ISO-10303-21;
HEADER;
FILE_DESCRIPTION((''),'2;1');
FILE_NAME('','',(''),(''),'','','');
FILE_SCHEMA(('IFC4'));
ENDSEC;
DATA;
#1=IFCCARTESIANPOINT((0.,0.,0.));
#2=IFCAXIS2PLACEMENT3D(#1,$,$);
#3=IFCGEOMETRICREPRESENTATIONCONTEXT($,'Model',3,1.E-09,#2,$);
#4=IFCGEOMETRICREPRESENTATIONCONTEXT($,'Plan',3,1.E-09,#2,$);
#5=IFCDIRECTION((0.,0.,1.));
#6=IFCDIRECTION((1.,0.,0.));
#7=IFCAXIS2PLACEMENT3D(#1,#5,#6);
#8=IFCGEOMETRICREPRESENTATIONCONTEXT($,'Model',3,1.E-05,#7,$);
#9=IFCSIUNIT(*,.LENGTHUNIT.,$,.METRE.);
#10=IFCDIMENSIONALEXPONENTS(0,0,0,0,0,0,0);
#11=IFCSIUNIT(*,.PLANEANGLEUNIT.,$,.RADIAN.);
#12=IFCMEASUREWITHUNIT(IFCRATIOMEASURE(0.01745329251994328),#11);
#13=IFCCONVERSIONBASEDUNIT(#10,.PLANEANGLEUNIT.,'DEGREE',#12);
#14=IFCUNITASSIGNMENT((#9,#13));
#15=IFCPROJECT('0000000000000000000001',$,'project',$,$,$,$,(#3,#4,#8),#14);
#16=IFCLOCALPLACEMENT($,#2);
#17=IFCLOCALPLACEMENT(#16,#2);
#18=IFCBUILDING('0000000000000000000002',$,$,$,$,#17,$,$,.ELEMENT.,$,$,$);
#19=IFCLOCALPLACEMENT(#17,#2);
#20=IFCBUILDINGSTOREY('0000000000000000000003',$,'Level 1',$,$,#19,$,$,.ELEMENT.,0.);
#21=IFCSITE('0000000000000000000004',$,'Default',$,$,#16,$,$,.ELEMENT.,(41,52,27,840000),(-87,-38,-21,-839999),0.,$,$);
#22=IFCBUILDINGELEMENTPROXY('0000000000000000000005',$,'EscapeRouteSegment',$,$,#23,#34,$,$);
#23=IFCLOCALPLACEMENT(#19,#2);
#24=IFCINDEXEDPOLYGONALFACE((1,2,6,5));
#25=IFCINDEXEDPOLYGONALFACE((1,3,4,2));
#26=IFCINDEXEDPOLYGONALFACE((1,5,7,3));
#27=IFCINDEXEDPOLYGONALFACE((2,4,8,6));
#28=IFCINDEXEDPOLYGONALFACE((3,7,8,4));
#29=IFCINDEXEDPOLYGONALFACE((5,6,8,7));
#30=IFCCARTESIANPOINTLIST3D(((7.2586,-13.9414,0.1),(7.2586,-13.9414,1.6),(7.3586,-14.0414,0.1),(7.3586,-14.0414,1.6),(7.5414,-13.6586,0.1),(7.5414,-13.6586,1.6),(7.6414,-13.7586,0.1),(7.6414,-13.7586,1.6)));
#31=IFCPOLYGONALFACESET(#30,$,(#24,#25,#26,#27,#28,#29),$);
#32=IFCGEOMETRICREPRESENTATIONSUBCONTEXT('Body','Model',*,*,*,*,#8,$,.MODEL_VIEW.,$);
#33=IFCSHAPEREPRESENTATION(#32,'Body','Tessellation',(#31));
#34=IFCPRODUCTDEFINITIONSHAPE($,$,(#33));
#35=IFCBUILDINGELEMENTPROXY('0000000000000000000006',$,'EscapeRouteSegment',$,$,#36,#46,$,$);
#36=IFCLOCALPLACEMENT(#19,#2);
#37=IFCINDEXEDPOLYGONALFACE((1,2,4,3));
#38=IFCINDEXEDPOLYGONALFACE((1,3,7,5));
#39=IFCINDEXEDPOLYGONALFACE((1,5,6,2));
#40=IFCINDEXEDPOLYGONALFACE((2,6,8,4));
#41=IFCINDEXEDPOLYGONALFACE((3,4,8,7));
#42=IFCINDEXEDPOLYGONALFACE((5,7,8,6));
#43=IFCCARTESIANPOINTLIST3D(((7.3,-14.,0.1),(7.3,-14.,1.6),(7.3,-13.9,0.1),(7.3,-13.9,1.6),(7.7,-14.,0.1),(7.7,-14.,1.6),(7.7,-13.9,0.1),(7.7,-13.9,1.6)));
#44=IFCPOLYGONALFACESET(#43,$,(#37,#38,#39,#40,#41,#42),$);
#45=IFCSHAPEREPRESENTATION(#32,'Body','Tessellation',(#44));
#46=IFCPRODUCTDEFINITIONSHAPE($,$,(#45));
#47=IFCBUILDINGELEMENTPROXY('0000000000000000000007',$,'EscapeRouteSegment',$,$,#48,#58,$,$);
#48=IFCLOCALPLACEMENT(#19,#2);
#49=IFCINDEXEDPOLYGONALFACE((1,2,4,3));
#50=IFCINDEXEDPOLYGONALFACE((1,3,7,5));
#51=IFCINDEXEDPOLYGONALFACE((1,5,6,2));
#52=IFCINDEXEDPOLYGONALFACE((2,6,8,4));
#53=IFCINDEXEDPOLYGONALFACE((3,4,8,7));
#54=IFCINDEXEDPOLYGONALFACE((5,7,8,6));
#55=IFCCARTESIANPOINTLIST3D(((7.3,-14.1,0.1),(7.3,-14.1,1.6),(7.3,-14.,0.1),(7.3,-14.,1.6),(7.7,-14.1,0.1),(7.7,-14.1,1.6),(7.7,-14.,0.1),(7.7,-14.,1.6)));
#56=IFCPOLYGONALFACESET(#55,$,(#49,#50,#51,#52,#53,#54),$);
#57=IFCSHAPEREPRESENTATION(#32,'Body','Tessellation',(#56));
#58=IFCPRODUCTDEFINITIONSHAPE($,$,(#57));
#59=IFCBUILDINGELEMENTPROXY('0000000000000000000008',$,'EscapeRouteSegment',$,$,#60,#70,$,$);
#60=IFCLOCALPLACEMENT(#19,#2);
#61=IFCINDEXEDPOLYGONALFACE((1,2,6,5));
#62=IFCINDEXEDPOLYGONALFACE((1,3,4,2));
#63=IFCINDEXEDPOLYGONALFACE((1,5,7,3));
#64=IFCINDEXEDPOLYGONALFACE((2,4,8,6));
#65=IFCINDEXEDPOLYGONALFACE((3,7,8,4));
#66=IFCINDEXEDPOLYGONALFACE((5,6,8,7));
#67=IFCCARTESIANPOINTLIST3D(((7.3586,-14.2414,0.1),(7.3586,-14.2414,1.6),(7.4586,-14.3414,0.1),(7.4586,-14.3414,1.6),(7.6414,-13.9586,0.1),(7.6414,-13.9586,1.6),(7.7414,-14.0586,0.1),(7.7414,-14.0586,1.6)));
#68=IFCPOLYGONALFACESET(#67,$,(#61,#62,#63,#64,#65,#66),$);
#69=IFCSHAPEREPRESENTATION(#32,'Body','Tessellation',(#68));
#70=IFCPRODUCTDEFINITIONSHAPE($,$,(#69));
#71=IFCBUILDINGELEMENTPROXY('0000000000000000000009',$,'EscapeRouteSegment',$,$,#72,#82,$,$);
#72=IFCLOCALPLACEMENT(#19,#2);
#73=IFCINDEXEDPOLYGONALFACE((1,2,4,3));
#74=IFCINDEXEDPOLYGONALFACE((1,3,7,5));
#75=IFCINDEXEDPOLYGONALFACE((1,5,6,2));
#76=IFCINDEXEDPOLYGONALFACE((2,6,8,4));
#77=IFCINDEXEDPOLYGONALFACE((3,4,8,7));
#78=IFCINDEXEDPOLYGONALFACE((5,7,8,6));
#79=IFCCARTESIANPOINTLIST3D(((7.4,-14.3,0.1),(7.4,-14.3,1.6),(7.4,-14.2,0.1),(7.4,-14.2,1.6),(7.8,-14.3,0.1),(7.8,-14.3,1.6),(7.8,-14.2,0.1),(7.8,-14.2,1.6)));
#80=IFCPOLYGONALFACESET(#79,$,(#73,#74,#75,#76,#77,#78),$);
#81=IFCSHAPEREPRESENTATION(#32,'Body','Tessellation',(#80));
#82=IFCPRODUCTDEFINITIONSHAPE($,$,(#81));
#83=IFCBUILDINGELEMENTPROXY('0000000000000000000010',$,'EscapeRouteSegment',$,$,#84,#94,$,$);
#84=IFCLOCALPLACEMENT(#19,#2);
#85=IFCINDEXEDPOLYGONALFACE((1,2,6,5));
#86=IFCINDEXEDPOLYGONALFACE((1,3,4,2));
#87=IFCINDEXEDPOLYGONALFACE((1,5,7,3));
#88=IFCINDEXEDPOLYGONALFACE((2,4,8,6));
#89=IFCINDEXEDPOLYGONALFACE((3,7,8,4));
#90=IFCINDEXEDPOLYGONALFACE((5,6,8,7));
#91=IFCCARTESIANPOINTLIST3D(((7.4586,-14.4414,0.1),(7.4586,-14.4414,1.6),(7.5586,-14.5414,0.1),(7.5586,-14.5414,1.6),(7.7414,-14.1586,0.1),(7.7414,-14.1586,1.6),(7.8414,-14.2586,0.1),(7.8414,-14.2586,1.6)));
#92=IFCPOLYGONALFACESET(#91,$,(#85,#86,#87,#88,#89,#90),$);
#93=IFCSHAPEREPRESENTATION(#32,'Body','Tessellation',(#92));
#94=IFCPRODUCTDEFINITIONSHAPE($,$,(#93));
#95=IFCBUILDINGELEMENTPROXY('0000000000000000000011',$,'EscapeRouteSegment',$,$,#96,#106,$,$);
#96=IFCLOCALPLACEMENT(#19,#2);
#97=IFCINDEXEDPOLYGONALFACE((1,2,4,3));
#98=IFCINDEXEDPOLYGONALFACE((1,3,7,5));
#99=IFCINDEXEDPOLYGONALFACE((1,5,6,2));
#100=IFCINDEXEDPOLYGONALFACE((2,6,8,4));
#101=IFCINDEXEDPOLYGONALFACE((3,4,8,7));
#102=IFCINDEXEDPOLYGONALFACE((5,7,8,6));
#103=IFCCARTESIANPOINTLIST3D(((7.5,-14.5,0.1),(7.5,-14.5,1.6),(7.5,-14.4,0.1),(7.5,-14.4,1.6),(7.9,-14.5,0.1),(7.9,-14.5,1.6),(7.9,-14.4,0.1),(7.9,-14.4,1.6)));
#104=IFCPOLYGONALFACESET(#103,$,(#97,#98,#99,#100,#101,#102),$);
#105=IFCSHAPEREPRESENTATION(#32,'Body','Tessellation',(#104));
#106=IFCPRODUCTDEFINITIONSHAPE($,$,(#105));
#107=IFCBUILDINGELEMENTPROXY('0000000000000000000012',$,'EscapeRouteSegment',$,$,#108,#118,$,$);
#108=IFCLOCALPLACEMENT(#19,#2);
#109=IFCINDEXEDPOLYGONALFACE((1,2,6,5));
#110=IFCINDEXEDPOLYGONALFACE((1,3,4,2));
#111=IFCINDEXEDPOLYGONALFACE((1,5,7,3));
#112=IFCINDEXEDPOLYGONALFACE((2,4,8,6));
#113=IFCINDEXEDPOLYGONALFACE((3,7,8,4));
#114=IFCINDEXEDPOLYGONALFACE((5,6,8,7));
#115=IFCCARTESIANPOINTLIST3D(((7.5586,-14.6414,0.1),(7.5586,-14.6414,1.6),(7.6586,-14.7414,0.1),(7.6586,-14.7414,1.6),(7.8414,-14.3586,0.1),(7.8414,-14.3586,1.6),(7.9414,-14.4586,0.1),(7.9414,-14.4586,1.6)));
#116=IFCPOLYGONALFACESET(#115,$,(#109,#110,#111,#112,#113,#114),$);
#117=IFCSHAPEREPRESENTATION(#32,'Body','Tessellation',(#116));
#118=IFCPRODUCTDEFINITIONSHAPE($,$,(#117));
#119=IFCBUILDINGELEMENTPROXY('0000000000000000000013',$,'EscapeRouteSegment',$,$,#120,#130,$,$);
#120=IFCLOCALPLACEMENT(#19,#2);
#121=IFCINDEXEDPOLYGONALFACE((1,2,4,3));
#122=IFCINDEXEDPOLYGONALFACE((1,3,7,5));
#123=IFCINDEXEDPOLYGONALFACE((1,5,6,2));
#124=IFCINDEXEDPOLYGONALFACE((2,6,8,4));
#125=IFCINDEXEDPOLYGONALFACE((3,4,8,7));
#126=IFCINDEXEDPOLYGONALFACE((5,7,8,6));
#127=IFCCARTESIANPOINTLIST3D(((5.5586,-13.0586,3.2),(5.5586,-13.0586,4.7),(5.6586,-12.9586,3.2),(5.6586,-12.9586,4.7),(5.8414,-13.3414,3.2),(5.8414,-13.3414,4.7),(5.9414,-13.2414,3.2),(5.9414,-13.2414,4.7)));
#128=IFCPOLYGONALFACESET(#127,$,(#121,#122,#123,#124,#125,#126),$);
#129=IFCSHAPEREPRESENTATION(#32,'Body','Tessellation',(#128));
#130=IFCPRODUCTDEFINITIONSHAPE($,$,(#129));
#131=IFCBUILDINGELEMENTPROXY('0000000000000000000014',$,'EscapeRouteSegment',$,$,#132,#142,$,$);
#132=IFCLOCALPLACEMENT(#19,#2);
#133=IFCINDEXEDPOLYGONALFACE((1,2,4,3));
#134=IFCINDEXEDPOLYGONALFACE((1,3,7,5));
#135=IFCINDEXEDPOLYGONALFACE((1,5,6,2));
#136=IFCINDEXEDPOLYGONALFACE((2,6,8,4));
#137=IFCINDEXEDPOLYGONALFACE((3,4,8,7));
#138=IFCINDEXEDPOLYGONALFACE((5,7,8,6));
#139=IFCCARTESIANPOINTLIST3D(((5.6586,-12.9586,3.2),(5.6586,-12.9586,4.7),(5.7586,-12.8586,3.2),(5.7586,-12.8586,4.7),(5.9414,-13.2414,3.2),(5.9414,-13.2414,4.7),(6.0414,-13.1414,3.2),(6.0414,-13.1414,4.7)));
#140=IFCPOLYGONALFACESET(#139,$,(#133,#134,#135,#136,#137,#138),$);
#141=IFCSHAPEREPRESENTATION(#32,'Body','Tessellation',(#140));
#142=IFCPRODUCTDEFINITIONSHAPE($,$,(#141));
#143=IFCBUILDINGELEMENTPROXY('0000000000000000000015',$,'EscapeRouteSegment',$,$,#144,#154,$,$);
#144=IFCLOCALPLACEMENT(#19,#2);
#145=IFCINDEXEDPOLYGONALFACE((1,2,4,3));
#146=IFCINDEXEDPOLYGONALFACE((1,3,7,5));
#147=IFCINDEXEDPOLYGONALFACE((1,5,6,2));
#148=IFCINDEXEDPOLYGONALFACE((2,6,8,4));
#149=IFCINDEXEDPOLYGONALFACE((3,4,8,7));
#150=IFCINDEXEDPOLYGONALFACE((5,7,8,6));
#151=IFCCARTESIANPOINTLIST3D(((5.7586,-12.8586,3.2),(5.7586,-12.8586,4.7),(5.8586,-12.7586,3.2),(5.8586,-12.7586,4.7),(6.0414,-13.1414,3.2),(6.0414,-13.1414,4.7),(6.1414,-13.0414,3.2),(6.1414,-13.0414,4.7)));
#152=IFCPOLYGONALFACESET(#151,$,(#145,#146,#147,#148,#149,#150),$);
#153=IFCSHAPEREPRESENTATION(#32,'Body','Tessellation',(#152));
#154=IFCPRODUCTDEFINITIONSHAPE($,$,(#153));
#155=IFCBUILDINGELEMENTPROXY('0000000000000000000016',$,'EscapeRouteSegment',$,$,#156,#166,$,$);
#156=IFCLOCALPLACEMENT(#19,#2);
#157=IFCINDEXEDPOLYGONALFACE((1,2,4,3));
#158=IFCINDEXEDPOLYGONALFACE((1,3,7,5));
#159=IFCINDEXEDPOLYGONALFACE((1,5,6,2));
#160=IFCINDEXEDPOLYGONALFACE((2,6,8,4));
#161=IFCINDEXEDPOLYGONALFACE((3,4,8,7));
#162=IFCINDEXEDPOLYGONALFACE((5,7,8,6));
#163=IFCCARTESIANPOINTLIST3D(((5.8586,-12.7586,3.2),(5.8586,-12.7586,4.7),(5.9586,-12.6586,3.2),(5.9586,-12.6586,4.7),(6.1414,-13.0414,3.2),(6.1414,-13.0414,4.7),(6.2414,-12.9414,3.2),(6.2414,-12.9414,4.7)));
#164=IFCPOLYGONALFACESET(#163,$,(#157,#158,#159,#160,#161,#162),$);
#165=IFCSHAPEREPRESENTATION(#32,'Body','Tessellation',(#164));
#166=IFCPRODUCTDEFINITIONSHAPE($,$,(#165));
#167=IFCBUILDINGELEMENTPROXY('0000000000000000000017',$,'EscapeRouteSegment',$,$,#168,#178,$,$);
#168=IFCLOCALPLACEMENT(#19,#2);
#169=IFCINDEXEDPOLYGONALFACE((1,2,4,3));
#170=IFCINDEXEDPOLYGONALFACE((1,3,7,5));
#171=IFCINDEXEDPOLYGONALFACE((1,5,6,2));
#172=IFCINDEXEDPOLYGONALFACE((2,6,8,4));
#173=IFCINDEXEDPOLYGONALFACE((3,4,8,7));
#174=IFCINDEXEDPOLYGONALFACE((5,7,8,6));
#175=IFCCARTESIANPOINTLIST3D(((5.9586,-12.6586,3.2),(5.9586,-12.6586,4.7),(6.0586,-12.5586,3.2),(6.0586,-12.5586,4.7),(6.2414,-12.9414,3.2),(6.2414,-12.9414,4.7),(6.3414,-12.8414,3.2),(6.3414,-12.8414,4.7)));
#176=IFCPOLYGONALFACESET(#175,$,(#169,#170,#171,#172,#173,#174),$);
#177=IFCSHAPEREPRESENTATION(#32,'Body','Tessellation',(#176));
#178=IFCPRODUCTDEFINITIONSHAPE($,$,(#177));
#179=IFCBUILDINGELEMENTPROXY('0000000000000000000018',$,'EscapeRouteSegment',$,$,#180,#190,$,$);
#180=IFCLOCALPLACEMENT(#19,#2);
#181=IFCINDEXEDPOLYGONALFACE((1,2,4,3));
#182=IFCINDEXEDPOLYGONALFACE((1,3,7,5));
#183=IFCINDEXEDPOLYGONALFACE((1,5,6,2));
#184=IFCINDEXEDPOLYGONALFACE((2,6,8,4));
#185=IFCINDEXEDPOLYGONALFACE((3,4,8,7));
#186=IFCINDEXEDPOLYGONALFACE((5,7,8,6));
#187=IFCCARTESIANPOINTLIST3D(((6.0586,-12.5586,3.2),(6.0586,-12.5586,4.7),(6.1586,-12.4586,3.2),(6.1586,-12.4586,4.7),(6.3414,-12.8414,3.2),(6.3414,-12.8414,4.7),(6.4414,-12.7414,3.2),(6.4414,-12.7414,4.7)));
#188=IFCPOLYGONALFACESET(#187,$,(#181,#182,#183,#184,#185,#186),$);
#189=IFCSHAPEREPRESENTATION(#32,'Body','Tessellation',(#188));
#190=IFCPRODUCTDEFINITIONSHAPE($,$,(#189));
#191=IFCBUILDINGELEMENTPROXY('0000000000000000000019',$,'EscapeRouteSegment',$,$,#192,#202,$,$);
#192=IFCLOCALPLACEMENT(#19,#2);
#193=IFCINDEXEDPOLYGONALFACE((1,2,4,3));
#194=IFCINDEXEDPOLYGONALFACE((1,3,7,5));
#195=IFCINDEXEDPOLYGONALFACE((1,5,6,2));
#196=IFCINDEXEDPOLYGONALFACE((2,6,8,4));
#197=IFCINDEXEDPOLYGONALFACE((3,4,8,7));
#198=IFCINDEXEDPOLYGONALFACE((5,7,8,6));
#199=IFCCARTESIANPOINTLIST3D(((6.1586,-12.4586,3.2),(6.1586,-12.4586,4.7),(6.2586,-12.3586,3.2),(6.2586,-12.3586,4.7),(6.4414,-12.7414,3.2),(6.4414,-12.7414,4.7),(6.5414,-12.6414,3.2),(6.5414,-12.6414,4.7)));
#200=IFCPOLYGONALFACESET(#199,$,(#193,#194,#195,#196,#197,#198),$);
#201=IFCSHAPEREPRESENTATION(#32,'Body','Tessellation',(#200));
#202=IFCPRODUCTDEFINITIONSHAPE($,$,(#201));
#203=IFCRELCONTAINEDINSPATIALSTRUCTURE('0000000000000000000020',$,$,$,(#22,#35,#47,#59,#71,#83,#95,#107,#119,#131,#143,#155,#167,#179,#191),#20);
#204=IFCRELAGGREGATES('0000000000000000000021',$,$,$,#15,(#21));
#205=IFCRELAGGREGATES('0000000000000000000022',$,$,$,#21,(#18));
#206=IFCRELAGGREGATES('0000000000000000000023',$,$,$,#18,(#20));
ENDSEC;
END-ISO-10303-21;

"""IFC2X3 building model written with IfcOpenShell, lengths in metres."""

from ifc_helpers import new_model, entity, si_unit, converted_unit, frame, origin, origin_with_axes, place, context, subcontext, project, spatial, polyline, outline, extrude, element, save


model = new_model("IFC2X3")

# Units and contexts
model_context_1 = context("Model", 3, precision=1e-09, world=origin())
plan_context = context("Plan", 3, precision=1e-09, world=origin())
model_context_2 = context("Model", 3, precision=1e-05, world=origin_with_axes())
body_context = subcontext(model_context_2, "Body", "Model", "MODEL_VIEW")
ifc_project = project(units=[si_unit("LENGTHUNIT", "METRE"), converted_unit("PLANEANGLEUNIT", "DEGREE", entity("IfcRatioMeasure", 0.01745329251994328), si_unit("PLANEANGLEUNIT", "RADIAN"), dimensions=[0, 0, 0, 0, 0, 0, 0])], contexts=[model_context_1, plan_context, model_context_2])

# Site, building, storey
site_placement = place(None, origin())
site = spatial("IfcSite", under=ifc_project, at=site_placement, Name="Default", CompositionType="ELEMENT", RefLatitude=(41, 52, 27, 840000), RefLongitude=(-87, -38, -21, -839999), RefElevation=0.0)
building_placement = place(site_placement, origin())
building = spatial("IfcBuilding", under=site, at=building_placement, CompositionType="ELEMENT")
storey_placement = place(building_placement, origin())
storey = spatial("IfcBuildingStorey", under=building, at=storey_placement, Name="Level 1", CompositionType="ELEMENT", Elevation=0.0)

# Building element proxies
proxy_1_placement = place(storey_placement, frame((7.4, -13.8, 0.1), z_axis=(0.0, 0.0, 1.0), x_axis=(0.707108, -0.707105, 0.0)))
element("IfcBuildingElementProxy", 1, at=proxy_1_placement, inside=storey, Name="EscapeRouteSegment", context=body_context, shape_type="SweptSolid", body=[
    extrude(outline(polyline([(0.0, -0.2), (0.0, 0.2), (0.1414, 0.2), (0.1414, -0.2), (0.0, -0.2)])), origin_with_axes(), (0.0, 0.0, 1.0), 1.5),
])
for number, where, z_axis, x_axis, name in (
    (2, (7.5, -13.9, 0.1), (0.0, 0.0, 1.0), (0.0, -1.0, 0.0), "EscapeRouteSegment"),
    (3, (7.5, -14.0, 0.1), (0.0, 0.0, 1.0), (0.0, -1.0, 0.0), "EscapeRouteSegment"),
):
    element("IfcBuildingElementProxy", number, at=place(storey_placement, frame(where, z_axis=z_axis, x_axis=x_axis)), inside=storey, Name=name, context=body_context, shape_type="SweptSolid", body=[
        extrude(outline(polyline([(0.0, -0.2), (0.0, 0.2), (0.1, 0.2), (0.1, -0.2), (0.0, -0.2)])), origin_with_axes(), (0.0, 0.0, 1.0), 1.5),
    ])
proxy_2_placement = place(storey_placement, frame((7.5, -14.1, 0.1), z_axis=(0.0, 0.0, 1.0), x_axis=(0.707108, -0.707105, 0.0)))
element("IfcBuildingElementProxy", 4, at=proxy_2_placement, inside=storey, Name="EscapeRouteSegment", context=body_context, shape_type="SweptSolid", body=[
    extrude(outline(polyline([(0.0, -0.2), (0.0, 0.2), (0.1414, 0.2), (0.1414, -0.2), (0.0, -0.2)])), origin_with_axes(), (0.0, 0.0, 1.0), 1.5),
])
proxy_3_placement = place(storey_placement, frame((7.6, -14.2, 0.1), z_axis=(0.0, 0.0, 1.0), x_axis=(0.0, -1.0, 0.0)))
element("IfcBuildingElementProxy", 5, at=proxy_3_placement, inside=storey, Name="EscapeRouteSegment", context=body_context, shape_type="SweptSolid", body=[
    extrude(outline(polyline([(0.0, -0.2), (0.0, 0.2), (0.1, 0.2), (0.1, -0.2), (0.0, -0.2)])), origin_with_axes(), (0.0, 0.0, 1.0), 1.5),
])
proxy_4_placement = place(storey_placement, frame((7.6, -14.3, 0.1), z_axis=(0.0, 0.0, 1.0), x_axis=(0.707108, -0.707105, 0.0)))
element("IfcBuildingElementProxy", 6, at=proxy_4_placement, inside=storey, Name="EscapeRouteSegment", context=body_context, shape_type="SweptSolid", body=[
    extrude(outline(polyline([(0.0, -0.2), (0.0, 0.2), (0.1414, 0.2), (0.1414, -0.2), (0.0, -0.2)])), origin_with_axes(), (0.0, 0.0, 1.0), 1.5),
])
proxy_5_placement = place(storey_placement, frame((7.7, -14.4, 0.1), z_axis=(0.0, 0.0, 1.0), x_axis=(0.0, -1.0, 0.0)))
element("IfcBuildingElementProxy", 7, at=proxy_5_placement, inside=storey, Name="EscapeRouteSegment", context=body_context, shape_type="SweptSolid", body=[
    extrude(outline(polyline([(0.0, -0.2), (0.0, 0.2), (0.1, 0.2), (0.1, -0.2), (0.0, -0.2)])), origin_with_axes(), (0.0, 0.0, 1.0), 1.5),
])
proxy_6_placement = place(storey_placement, frame((7.7, -14.5, 0.1), z_axis=(0.0, 0.0, 1.0), x_axis=(0.707107, -0.707107, 0.0)))
element("IfcBuildingElementProxy", 8, at=proxy_6_placement, inside=storey, Name="EscapeRouteSegment", context=body_context, shape_type="SweptSolid", body=[
    extrude(outline(polyline([(0.0, -0.2), (0.0, 0.2), (0.1414, 0.2), (0.1414, -0.2), (0.0, -0.2)])), origin_with_axes(), (0.0, 0.0, 1.0), 1.5),
])
proxy_7_placement = place(storey_placement, frame((5.7, -13.2, 3.2), z_axis=(0.0, 0.0, 1.0), x_axis=(0.70711, 0.707104, 0.0)))
element("IfcBuildingElementProxy", 9, at=proxy_7_placement, inside=storey, Name="EscapeRouteSegment", context=body_context, shape_type="SweptSolid", body=[
    extrude(outline(polyline([(0.0, -0.2), (0.0, 0.2), (0.1414, 0.2), (0.1414, -0.2), (0.0, -0.2)])), origin_with_axes(), (0.0, 0.0, 1.0), 1.5),
])
for number, where, z_axis, x_axis, name in (
    (10, (5.8, -13.1, 3.2), (0.0, 0.0, 1.0), (0.707105, 0.707108, 0.0), "EscapeRouteSegment"),
    (11, (5.9, -13.0, 3.2), (0.0, 0.0, 1.0), (0.707105, 0.707108, 0.0), "EscapeRouteSegment"),
):
    element("IfcBuildingElementProxy", number, at=place(storey_placement, frame(where, z_axis=z_axis, x_axis=x_axis)), inside=storey, Name=name, context=body_context, shape_type="SweptSolid", body=[
        extrude(outline(polyline([(0.0, -0.2), (0.0, 0.2), (0.1414, 0.2), (0.1414, -0.2), (0.0, -0.2)])), origin_with_axes(), (0.0, 0.0, 1.0), 1.5),
    ])
proxy_8_placement = place(storey_placement, frame((6.0, -12.9, 3.2), z_axis=(0.0, 0.0, 1.0), x_axis=(0.707108, 0.707105, 0.0)))
element("IfcBuildingElementProxy", 12, at=proxy_8_placement, inside=storey, Name="EscapeRouteSegment", context=body_context, shape_type="SweptSolid", body=[
    extrude(outline(polyline([(0.0, -0.2), (0.0, 0.2), (0.1414, 0.2), (0.1414, -0.2), (0.0, -0.2)])), origin_with_axes(), (0.0, 0.0, 1.0), 1.5),
])
proxy_9_placement = place(storey_placement, frame((6.1, -12.8, 3.2), z_axis=(0.0, 0.0, 1.0), x_axis=(0.707105, 0.707108, 0.0)))
element("IfcBuildingElementProxy", 13, at=proxy_9_placement, inside=storey, Name="EscapeRouteSegment", context=body_context, shape_type="SweptSolid", body=[
    extrude(outline(polyline([(0.0, -0.2), (0.0, 0.2), (0.1414, 0.2), (0.1414, -0.2), (0.0, -0.2)])), origin_with_axes(), (0.0, 0.0, 1.0), 1.5),
])
proxy_10_placement = place(storey_placement, frame((6.2, -12.7, 3.2), z_axis=(0.0, 0.0, 1.0), x_axis=(0.70711, 0.707104, 0.0)))
element("IfcBuildingElementProxy", 14, at=proxy_10_placement, inside=storey, Name="EscapeRouteSegment", context=body_context, shape_type="SweptSolid", body=[
    extrude(outline(polyline([(0.0, -0.2), (0.0, 0.2), (0.1414, 0.2), (0.1414, -0.2), (0.0, -0.2)])), origin_with_axes(), (0.0, 0.0, 1.0), 1.5),
])
proxy_11_placement = place(storey_placement, frame((6.3, -12.6, 3.2), z_axis=(0.0, 0.0, 1.0), x_axis=(0.707105, 0.707108, 0.0)))
element("IfcBuildingElementProxy", 15, at=proxy_11_placement, inside=storey, Name="EscapeRouteSegment", context=body_context, shape_type="SweptSolid", body=[
    extrude(outline(polyline([(0.0, -0.2), (0.0, 0.2), (0.1414, 0.2), (0.1414, -0.2), (0.0, -0.2)])), origin_with_axes(), (0.0, 0.0, 1.0), 1.5),
])

save(model, "model.ifc")
